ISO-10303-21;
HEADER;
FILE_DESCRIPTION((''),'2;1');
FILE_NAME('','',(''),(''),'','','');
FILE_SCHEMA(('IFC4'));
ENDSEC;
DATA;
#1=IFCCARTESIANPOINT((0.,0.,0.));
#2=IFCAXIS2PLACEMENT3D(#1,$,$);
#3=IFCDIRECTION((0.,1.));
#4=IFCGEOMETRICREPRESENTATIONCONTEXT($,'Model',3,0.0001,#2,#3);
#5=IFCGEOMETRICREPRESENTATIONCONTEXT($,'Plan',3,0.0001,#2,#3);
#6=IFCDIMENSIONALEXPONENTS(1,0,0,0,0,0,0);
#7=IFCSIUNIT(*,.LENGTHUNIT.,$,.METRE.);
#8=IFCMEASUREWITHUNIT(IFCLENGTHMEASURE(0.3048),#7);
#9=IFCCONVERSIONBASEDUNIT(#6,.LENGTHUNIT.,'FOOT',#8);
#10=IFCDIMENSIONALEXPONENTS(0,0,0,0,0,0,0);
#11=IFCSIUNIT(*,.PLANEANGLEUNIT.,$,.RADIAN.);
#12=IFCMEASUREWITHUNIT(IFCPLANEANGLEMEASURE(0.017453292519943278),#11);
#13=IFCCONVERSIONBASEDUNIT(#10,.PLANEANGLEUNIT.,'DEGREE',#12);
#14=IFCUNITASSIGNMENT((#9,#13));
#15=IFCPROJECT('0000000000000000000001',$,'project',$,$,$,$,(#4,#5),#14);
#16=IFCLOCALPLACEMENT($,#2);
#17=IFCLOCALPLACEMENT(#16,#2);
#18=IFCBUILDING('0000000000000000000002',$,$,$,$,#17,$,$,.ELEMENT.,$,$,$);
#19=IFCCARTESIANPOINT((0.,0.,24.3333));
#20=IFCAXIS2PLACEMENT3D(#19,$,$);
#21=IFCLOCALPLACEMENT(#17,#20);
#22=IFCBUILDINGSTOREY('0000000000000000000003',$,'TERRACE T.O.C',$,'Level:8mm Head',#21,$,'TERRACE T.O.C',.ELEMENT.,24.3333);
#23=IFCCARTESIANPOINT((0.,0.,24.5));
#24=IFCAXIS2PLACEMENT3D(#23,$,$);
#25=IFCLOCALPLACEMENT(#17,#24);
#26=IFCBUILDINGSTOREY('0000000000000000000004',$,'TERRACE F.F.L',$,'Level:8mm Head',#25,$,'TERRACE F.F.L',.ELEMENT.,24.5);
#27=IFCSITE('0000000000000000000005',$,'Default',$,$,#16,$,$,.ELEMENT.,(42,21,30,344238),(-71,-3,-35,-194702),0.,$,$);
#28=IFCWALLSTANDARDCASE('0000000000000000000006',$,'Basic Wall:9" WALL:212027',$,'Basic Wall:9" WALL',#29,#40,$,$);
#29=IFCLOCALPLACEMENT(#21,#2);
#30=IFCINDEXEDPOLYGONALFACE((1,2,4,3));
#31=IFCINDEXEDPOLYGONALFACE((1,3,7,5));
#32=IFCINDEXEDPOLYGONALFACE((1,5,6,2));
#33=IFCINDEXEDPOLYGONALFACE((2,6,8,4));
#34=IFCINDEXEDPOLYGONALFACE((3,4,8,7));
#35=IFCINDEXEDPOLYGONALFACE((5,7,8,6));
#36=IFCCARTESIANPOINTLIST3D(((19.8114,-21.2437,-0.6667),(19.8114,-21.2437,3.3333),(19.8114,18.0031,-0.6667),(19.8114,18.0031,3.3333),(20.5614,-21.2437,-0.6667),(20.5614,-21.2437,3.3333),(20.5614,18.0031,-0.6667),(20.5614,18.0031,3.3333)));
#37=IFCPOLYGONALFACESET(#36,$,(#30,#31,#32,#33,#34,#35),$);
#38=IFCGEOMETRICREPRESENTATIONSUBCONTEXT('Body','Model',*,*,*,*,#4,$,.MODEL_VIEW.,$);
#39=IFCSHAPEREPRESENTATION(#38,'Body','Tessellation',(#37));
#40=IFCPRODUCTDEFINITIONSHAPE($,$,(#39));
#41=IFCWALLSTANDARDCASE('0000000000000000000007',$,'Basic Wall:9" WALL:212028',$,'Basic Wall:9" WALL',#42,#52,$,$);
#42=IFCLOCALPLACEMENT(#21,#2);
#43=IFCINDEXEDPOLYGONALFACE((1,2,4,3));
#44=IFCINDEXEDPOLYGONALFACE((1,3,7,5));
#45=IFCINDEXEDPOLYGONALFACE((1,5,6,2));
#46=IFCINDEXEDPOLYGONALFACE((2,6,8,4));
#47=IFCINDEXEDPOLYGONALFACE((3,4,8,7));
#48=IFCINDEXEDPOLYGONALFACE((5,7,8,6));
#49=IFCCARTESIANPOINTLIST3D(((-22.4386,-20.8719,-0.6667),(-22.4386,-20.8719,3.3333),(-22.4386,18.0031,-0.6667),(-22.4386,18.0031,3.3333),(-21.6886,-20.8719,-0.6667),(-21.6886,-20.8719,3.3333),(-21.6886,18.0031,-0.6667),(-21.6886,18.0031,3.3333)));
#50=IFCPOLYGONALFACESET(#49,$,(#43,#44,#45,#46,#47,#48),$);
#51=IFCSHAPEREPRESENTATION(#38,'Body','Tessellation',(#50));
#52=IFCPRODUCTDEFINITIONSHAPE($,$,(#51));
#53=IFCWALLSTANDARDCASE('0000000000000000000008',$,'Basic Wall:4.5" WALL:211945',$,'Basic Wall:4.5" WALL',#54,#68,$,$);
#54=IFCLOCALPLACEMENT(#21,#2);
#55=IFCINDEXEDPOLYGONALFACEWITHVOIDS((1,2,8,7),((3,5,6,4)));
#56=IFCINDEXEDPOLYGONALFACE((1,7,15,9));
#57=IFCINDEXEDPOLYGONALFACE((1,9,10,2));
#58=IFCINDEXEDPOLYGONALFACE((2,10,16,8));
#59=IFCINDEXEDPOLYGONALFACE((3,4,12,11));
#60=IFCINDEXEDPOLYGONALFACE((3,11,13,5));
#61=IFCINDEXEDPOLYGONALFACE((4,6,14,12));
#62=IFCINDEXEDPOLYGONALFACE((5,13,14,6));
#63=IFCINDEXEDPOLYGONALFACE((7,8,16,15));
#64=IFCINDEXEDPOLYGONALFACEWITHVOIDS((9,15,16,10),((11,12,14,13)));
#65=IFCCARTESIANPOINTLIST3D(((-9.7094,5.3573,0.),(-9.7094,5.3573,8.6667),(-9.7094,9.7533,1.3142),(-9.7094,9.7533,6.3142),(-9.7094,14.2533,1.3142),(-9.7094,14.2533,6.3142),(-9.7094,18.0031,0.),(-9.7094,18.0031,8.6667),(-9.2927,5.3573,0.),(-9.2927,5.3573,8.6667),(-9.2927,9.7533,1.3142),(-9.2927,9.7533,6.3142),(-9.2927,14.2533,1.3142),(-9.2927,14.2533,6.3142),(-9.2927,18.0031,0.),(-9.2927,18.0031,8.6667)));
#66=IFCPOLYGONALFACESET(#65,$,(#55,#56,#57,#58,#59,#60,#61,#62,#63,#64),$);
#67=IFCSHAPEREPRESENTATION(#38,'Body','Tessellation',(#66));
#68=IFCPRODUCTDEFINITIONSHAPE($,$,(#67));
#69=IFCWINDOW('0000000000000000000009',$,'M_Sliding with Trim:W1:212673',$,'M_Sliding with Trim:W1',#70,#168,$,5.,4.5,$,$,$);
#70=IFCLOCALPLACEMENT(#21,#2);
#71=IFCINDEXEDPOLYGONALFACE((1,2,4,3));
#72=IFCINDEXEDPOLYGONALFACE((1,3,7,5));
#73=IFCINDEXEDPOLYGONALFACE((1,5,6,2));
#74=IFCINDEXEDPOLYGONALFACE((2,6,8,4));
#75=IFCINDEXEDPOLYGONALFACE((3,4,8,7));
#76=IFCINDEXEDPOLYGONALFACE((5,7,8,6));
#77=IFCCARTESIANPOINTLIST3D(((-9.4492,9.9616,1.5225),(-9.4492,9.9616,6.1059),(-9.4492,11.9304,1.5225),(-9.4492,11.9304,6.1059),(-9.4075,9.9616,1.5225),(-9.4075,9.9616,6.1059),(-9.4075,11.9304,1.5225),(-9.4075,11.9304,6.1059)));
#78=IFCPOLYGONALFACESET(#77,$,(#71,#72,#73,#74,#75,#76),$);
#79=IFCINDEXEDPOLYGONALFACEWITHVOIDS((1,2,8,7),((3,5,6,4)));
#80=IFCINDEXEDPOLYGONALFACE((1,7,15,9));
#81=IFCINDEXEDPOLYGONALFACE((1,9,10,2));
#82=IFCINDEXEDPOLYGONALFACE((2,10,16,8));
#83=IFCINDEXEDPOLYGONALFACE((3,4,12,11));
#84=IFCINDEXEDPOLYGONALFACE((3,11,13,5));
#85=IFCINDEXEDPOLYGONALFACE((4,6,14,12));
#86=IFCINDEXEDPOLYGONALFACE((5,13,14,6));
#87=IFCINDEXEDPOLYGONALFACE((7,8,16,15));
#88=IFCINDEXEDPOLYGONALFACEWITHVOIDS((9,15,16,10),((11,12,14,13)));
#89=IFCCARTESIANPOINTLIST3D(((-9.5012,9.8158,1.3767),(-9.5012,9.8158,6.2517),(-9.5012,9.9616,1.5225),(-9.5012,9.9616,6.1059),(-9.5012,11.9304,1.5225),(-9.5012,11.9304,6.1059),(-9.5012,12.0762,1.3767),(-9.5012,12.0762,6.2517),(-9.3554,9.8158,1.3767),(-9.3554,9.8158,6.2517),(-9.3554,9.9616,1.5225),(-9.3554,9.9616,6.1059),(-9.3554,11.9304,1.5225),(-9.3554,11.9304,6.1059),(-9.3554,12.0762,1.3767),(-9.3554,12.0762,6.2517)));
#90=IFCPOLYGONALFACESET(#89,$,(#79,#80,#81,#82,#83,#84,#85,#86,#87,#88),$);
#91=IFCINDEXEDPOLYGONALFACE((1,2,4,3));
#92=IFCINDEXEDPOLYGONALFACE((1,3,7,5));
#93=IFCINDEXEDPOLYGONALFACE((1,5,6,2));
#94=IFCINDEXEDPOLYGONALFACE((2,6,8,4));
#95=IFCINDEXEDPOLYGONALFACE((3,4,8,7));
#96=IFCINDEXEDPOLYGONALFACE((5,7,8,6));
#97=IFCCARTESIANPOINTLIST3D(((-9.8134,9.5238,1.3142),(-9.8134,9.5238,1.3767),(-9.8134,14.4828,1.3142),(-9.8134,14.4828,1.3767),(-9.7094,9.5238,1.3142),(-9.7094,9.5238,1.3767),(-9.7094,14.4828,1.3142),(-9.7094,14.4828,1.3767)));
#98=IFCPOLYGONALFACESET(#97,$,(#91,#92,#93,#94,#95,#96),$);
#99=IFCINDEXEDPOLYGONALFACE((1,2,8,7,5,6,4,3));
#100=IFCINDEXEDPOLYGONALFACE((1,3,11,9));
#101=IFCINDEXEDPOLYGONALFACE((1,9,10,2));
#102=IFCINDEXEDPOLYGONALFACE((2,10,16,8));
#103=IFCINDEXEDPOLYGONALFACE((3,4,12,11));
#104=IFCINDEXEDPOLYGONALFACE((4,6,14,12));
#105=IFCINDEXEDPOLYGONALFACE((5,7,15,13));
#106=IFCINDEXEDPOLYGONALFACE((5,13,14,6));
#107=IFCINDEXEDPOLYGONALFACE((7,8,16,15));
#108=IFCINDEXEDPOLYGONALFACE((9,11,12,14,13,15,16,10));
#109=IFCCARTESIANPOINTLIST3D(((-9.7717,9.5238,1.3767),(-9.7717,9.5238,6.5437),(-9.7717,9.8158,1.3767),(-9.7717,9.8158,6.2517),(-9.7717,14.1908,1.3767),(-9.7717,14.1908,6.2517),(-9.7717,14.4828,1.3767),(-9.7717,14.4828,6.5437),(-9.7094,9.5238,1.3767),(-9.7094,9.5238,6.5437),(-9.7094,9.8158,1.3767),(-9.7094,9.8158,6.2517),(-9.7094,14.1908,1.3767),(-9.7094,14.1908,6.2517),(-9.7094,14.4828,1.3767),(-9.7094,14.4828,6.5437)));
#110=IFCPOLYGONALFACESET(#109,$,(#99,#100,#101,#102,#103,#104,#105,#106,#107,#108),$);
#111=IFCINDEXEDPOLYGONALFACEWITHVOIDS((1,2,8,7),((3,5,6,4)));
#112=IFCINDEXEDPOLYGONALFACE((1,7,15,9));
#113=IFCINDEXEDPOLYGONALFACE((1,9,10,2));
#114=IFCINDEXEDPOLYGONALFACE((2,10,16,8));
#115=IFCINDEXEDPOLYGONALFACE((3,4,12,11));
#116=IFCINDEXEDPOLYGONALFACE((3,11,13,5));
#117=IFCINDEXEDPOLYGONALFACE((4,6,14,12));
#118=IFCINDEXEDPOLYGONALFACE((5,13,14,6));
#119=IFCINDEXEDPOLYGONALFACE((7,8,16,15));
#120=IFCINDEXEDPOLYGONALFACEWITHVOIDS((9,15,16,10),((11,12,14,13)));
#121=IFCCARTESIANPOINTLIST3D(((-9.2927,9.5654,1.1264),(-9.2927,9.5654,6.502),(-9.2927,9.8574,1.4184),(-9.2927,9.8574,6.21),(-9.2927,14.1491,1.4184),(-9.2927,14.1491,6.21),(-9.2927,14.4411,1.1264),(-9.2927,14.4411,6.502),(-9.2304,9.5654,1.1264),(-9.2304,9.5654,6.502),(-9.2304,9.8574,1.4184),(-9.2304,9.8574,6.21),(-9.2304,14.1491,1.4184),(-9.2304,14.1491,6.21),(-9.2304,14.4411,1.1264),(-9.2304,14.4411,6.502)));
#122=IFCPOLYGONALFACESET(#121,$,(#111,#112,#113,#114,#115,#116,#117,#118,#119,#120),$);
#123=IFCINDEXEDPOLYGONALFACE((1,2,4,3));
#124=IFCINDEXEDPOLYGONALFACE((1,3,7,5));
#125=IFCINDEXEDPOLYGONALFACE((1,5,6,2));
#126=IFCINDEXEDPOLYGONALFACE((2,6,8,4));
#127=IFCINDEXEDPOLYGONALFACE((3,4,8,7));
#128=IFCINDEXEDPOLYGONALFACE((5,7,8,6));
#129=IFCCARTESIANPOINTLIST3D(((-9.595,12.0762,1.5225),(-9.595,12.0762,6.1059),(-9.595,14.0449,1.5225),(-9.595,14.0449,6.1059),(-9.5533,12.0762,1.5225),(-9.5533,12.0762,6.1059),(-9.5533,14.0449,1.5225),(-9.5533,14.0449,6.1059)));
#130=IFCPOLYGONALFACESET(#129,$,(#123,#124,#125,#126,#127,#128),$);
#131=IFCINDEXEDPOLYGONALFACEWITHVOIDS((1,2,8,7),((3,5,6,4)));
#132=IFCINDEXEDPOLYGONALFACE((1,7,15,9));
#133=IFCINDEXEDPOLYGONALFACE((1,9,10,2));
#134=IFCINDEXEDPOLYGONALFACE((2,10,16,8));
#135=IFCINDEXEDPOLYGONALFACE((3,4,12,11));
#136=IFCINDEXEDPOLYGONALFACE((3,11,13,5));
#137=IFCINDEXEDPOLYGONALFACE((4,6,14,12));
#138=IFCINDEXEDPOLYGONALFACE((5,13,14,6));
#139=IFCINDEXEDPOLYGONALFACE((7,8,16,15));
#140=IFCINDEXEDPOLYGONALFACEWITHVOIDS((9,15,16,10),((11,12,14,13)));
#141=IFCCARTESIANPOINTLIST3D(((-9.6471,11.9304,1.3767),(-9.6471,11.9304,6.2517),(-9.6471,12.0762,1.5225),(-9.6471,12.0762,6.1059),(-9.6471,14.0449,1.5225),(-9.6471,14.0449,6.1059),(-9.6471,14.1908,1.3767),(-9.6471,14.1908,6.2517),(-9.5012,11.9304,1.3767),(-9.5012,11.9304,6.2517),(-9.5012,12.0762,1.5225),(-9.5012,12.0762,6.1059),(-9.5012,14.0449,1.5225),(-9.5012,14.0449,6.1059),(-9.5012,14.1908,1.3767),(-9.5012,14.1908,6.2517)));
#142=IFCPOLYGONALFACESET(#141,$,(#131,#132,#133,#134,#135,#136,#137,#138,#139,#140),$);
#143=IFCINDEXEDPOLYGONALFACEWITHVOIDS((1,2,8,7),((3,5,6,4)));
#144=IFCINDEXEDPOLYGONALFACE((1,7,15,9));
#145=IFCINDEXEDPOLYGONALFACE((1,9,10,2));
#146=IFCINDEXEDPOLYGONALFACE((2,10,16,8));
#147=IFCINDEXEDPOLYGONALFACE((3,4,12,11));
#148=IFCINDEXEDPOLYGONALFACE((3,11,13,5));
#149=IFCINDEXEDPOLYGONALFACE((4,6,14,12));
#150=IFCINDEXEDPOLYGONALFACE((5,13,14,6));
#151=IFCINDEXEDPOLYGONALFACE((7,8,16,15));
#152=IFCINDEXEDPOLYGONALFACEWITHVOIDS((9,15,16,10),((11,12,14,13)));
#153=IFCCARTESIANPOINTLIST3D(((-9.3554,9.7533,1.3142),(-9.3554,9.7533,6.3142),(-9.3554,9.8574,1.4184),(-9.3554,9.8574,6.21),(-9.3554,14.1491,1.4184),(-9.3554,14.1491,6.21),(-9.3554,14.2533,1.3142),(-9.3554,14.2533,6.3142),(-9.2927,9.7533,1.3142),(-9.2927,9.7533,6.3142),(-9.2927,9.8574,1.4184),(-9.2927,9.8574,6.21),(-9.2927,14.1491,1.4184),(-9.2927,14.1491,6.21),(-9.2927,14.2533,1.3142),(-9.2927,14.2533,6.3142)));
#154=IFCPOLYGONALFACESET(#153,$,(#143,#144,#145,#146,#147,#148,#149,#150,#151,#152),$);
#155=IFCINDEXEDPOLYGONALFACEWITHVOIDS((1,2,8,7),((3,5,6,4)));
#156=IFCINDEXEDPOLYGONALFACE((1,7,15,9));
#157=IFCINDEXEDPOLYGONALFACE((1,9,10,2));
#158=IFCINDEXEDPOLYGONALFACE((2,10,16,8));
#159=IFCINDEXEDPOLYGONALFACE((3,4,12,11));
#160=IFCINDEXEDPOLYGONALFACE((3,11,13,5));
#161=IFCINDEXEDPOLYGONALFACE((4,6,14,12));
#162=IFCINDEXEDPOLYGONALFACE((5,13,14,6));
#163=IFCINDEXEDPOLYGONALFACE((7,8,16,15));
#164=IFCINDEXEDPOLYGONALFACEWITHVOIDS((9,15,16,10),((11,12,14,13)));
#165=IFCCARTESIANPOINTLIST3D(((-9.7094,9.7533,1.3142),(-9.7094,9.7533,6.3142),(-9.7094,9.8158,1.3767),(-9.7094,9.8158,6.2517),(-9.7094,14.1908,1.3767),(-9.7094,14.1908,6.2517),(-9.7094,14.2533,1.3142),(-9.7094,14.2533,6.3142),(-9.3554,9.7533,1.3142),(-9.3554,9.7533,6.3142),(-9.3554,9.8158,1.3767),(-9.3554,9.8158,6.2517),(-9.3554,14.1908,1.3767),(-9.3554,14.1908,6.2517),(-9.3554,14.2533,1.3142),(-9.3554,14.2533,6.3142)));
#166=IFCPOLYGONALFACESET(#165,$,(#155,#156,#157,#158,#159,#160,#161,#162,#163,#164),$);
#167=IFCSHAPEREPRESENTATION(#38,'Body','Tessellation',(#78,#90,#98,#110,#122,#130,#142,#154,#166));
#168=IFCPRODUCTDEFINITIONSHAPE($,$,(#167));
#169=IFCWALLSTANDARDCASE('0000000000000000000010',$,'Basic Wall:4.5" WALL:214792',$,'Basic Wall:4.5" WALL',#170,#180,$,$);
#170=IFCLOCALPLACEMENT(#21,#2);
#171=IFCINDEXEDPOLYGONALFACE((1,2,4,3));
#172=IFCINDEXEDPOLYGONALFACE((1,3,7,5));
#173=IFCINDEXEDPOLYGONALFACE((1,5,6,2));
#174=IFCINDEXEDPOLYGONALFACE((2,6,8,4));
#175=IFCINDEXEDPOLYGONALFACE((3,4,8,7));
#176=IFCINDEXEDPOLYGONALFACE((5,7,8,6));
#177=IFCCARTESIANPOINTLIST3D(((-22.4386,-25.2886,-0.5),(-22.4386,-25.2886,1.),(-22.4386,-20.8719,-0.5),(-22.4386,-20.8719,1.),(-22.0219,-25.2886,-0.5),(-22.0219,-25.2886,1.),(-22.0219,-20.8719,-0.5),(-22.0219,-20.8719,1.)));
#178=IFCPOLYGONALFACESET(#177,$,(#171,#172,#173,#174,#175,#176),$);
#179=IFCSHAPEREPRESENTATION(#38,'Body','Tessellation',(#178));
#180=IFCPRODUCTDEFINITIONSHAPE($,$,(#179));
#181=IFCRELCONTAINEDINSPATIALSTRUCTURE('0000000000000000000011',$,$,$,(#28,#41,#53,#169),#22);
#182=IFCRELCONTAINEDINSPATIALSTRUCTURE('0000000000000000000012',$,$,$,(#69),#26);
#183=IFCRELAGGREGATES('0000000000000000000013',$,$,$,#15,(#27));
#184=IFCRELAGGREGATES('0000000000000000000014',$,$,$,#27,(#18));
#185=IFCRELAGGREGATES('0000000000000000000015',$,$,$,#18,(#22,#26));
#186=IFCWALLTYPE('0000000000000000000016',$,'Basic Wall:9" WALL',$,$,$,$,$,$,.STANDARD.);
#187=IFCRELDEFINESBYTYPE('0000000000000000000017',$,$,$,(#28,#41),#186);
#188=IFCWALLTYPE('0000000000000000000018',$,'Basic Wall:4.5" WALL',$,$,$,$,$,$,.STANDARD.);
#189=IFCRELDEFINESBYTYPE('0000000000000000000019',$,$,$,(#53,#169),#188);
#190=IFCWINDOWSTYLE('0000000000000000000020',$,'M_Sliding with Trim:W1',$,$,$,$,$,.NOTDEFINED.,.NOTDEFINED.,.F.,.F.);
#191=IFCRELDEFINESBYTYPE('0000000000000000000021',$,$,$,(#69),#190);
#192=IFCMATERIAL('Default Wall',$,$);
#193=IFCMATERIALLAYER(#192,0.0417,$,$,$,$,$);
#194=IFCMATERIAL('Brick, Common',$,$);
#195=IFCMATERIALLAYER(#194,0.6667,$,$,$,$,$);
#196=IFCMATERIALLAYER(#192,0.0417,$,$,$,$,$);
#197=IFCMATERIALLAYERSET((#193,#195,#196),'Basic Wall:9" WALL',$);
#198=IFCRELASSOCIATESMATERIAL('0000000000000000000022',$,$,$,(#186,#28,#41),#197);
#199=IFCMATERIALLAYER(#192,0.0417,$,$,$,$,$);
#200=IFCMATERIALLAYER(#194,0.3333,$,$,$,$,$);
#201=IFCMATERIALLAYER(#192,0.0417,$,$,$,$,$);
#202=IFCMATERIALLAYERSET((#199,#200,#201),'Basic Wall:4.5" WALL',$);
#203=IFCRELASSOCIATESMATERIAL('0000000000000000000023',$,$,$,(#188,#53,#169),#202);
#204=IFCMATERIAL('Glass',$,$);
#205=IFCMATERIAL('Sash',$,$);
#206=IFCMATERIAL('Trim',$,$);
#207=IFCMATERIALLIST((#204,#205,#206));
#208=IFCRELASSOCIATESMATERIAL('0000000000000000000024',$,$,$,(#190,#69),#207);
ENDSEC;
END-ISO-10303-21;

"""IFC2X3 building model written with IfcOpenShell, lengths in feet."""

from ifc_helpers import new_model, entity, si_unit, converted_unit, direction, frame, frame_2d, origin, origin_2d_with_axis, place, context, subcontext, project, spatial, polyline, rectangle, outline, extrude, clip, bounded_halfspace, source, transform, mapped, material, material_list, layer, layer_set, layer_usage, type_object, type_shapes, element, fill, save


model = new_model("IFC2X3")

# Units and contexts
model_context = context("Model", 3, precision=0.0001, world=origin(), true_north=direction((0.0, 1.0)))
plan_context = context("Plan", 3, precision=0.0001, world=origin(), true_north=direction((0.0, 1.0)))
body_context = subcontext(model_context, "Body", "Model", "MODEL_VIEW")
ifc_project = project(units=[converted_unit("LENGTHUNIT", "FOOT", entity("IfcLengthMeasure", 0.3048), si_unit("LENGTHUNIT", "METRE"), dimensions=[1, 0, 0, 0, 0, 0, 0]), converted_unit("PLANEANGLEUNIT", "DEGREE", entity("IfcPlaneAngleMeasure", 0.017453292519943278), si_unit("PLANEANGLEUNIT", "RADIAN"), dimensions=[0, 0, 0, 0, 0, 0, 0])], contexts=[model_context, plan_context])

# Site, building, storey
site_placement = place(None, origin())
site = spatial("IfcSite", under=ifc_project, at=site_placement, Name="Default", CompositionType="ELEMENT", RefLatitude=(42, 21, 30, 344238), RefLongitude=(-71, -3, -35, -194702), RefElevation=0.0)
building_placement = place(site_placement, origin())
building = spatial("IfcBuilding", under=site, at=building_placement, CompositionType="ELEMENT")
storey_1_placement = place(building_placement, frame((0.0, 0.0, 24.3333)))
storey_1 = spatial("IfcBuildingStorey", under=building, at=storey_1_placement, Name="TERRACE T.O.C", ObjectType="Level:8mm Head", LongName="TERRACE T.O.C", CompositionType="ELEMENT", Elevation=24.3333)

# Walls
ifc_material_1 = material(Name="Default Wall")
ifc_layer_1 = layer(ifc_material_1, 0.0417)
ifc_material_2 = material(Name="Brick, Common")
ifc_layer_2 = layer(ifc_material_2, 0.6667)
ifc_layer_3 = layer(ifc_material_1, 0.0417)
ifc_layer_set_1 = layer_set([ifc_layer_1, ifc_layer_2, ifc_layer_3], Name="Basic Wall:9\" WALL")
ifc_layer_usage_1 = layer_usage(ifc_layer_set_1, "AXIS2", "NEGATIVE", 0.375)
wall_type_1 = type_object("IfcWallType", Name="Basic Wall:9\" WALL", PredefinedType="STANDARD", material=ifc_layer_set_1)
wall_1_placement = place(storey_1_placement, frame((20.1864, 18.0031, -0.6667), z_axis=(0.0, 0.0, 1.0), x_axis=(0.0, -1.0, 0.0)))
element("IfcWallStandardCase", 1, at=wall_1_placement, inside=storey_1, type_object=wall_type_1, material=ifc_layer_usage_1, Name="Basic Wall:9\" WALL:212027", ObjectType="Basic Wall:9\" WALL", context=body_context, shape_type="SweptSolid", body=[
    extrude(rectangle(XDim=39.2468, YDim=0.75, at=frame_2d((19.6234, 0.0), x_axis=(-1.0, 0.0))), origin(), (0.0, 0.0, 1.0), 4.0),
])
ifc_layer_usage_2 = layer_usage(ifc_layer_set_1, "AXIS2", "NEGATIVE", 0.375)
wall_2_placement = place(storey_1_placement, frame((-22.0636, 18.0031, -0.6667), z_axis=(0.0, 0.0, 1.0), x_axis=(0.0, -1.0, 0.0)))
element("IfcWallStandardCase", 2, at=wall_2_placement, inside=storey_1, type_object=wall_type_1, material=ifc_layer_usage_2, Name="Basic Wall:9\" WALL:212028", ObjectType="Basic Wall:9\" WALL", context=body_context, shape_type="SweptSolid", body=[
    extrude(rectangle(XDim=38.875, YDim=0.75, at=frame_2d((19.4375, 0.0), x_axis=(-1.0, 0.0))), origin(), (0.0, 0.0, 1.0), 4.0),
])

# Wall, opening
ifc_layer_4 = layer(ifc_material_1, 0.0417)
ifc_layer_5 = layer(ifc_material_2, 0.3333)
ifc_layer_6 = layer(ifc_material_1, 0.0417)
ifc_layer_set_2 = layer_set([ifc_layer_4, ifc_layer_5, ifc_layer_6], Name="Basic Wall:4.5\" WALL")
ifc_layer_usage_3 = layer_usage(ifc_layer_set_2, "AXIS2", "NEGATIVE", 0.2083)
wall_type_2 = type_object("IfcWallType", Name="Basic Wall:4.5\" WALL", PredefinedType="STANDARD", material=ifc_layer_set_2)
wall_3_placement = place(storey_1_placement, frame((-9.5011, 18.0031, 0.0), z_axis=(0.0, 0.0, 1.0), x_axis=(0.0, -1.0, 0.0)))
wall_3 = element("IfcWallStandardCase", 3, at=wall_3_placement, inside=storey_1, type_object=wall_type_2, material=ifc_layer_usage_3, Name="Basic Wall:4.5\" WALL:211945", ObjectType="Basic Wall:4.5\" WALL", context=body_context, shape_type="Clipping", body=[
    clip(extrude(rectangle(XDim=12.6458, YDim=0.4167, at=frame_2d((6.3229, 0.0), x_axis=(-1.0, 0.0))), origin(), (0.0, 0.0, 1.0), 8.6667), bounded_halfspace(frame((0.0, -0.2083, 8.6667), z_axis=(0.0, 0.0, -1.0), x_axis=(1.0, 0.0, 0.0)), True, frame((0.0, -0.2083, 8.6667)), polyline([(0.0, 0.0), (12.6458, 0.0), (12.6458, 0.4167), (12.2292, 0.4167), (0.0, 0.4167), (0.0, 0.0)]))),
])
opening_1_placement = place(wall_3_placement, frame((8.2498, 0.2083, 1.3142)))
opening_1 = element("IfcOpeningElement", 4, at=opening_1_placement, cuts=wall_3, ObjectType="Opening", context=body_context, shape_type="SweptSolid", body=[
    extrude(rectangle(XDim=5.0, YDim=4.5, at=frame_2d((2.5, 2.25), x_axis=(-1.0, 0.0))), frame((0.0, 0.0, 0.0), z_axis=(0.0, -1.0, 0.0), x_axis=(0.0, 0.0, 1.0)), (0.0, 0.0, 1.0), 0.4167),
])

# Shared definitions
storey_2_placement = place(building_placement, frame((0.0, 0.0, 24.5)))
storey_2 = spatial("IfcBuildingStorey", under=building, at=storey_2_placement, Name="TERRACE F.F.L", ObjectType="Level:8mm Head", LongName="TERRACE F.F.L", CompositionType="ELEMENT", Elevation=24.5)

# Window
ifc_material_3 = material(Name="Glass")
ifc_material_4 = material(Name="Sash")
ifc_material_5 = material(Name="Trim")
ifc_material_list_1 = material_list([ifc_material_3, ifc_material_4, ifc_material_5])
window_style = type_object("IfcWindowStyle", Name="M_Sliding with Trim:W1", ConstructionType="NOTDEFINED", OperationType="NOTDEFINED", ParameterTakesPrecedence=False, Sizeable=False, material=ifc_material_list_1)
shared_shape_1 = source(origin(), body_context, "Body", "SweptSolid", [
    extrude(rectangle(XDim=0.0417, YDim=1.9688, at=frame_2d((0.0, 0.0), x_axis=(1.0, 0.0))), frame((1.1927, 0.1356, 0.2083), z_axis=(0.0, 0.0, 1.0), x_axis=(0.0, -1.0, 0.0)), (0.0, 0.0, 1.0), 4.5833),
    extrude(outline(polyline([(-1.1302, -2.4375), (1.1302, -2.4375), (1.1302, 2.4375), (-1.1302, 2.4375), (-1.1302, -2.4375)]), holes=[polyline([(-0.9844, -2.2917), (-0.9844, 2.2917), (0.9844, 2.2917), (0.9844, -2.2917), (-0.9844, -2.2917)])]), frame((1.1927, 0.0627, 2.5), z_axis=(0.0, 1.0, 0.0), x_axis=(1.0, 0.0, 0.0)), (0.0, 0.0, 1.0), 0.1458),
    extrude(rectangle(XDim=0.104, YDim=4.959, at=frame_2d((0.0, 0.0), x_axis=(1.0, 0.0))), frame((2.25, 0.4687, 0.0), z_axis=(0.0, 0.0, 1.0), x_axis=(0.0, -1.0, 0.0)), (0.0, 0.0, 1.0), 0.0625),
    extrude(outline(polyline([(-2.3645, 2.1875), (2.5105, 2.1875), (2.5105, 2.4795), (-2.6565, 2.4795), (-2.6565, -2.4795), (2.5105, -2.4795), (2.5105, -2.1875), (-2.3645, -2.1875), (-2.3645, 2.1875)])), frame((2.25, 0.4167, 2.573), z_axis=(0.0, 1.0, 0.0), x_axis=(0.0, 0.0, -1.0)), (0.0, 0.0, 1.0), 0.0623),
    extrude(outline(polyline([(-2.6878, -2.4378), (2.6878, -2.4378), (2.6878, 2.4378), (-2.6878, 2.4378), (-2.6878, -2.4378)]), holes=[polyline([(-2.3958, -2.1458), (-2.3958, 2.1458), (2.3958, 2.1458), (2.3958, -2.1458), (-2.3958, -2.1458)])]), frame((2.25, -0.0623, 2.5), z_axis=(0.0, 1.0, 0.0), x_axis=(0.0, 0.0, -1.0)), (0.0, 0.0, 1.0), 0.0623),
    extrude(rectangle(XDim=0.0417, YDim=1.9687, at=origin_2d_with_axis()), frame((3.3073, 0.2814, 0.2083), z_axis=(0.0, 0.0, 1.0), x_axis=(0.0, 1.0, 0.0)), (0.0, 0.0, 1.0), 4.5833),
    extrude(outline(polyline([(-1.1302, -2.4375), (1.1302, -2.4375), (1.1302, 2.4375), (-1.1302, 2.4375), (-1.1302, -2.4375)]), holes=[polyline([(-0.9844, -2.2917), (-0.9844, 2.2917), (0.9844, 2.2917), (0.9844, -2.2917), (-0.9844, -2.2917)])]), frame((3.3073, 0.2085, 2.5), z_axis=(0.0, 1.0, 0.0), x_axis=(1.0, 0.0, 0.0)), (0.0, 0.0, 1.0), 0.1458),
    extrude(outline(polyline([(-2.25, -2.5), (2.25, -2.5), (2.25, 2.5), (-2.25, 2.5), (-2.25, -2.5)]), holes=[polyline([(-2.1458, -2.3958), (-2.1458, 2.3958), (2.1458, 2.3958), (2.1458, -2.3958), (-2.1458, -2.3958)])]), frame((2.25, 0.0, 2.5), z_axis=(0.0, 1.0, 0.0), x_axis=(1.0, 0.0, 0.0)), (0.0, 0.0, 1.0), 0.0627),
    extrude(outline(polyline([(-2.5, -2.25), (2.5, -2.25), (2.5, 2.25), (-2.5, 2.25), (-2.5, -2.25)]), holes=[polyline([(-2.4375, -2.1875), (-2.4375, 2.1875), (2.4375, 2.1875), (2.4375, -2.1875), (-2.4375, -2.1875)])]), frame((2.25, 0.0627, 2.5), z_axis=(0.0, 1.0, 0.0), x_axis=(0.0, 0.0, -1.0)), (0.0, 0.0, 1.0), 0.354),
])
type_shapes(window_style, [shared_shape_1])
window_placement = place(opening_1_placement, frame((0.0, 0.0, 0.0), z_axis=(0.0, 0.0, 1.0), x_axis=(-1.0, 0.0, 0.0)))
window = element("IfcWindow", 5, at=window_placement, inside=storey_2, type_object=window_style, material=ifc_material_list_1, Name="M_Sliding with Trim:W1:212673", ObjectType="M_Sliding with Trim:W1", OverallHeight=5.0, OverallWidth=4.5, context=body_context, shape_type="MappedRepresentation", body=[
    mapped(shared_shape_1, transform((0.0, 0.0, 0.0), scale=1.0)),
])
fill(opening_1, window)

# Wall
ifc_layer_usage_4 = layer_usage(ifc_layer_set_2, "AXIS2", "NEGATIVE", 0.2083)
wall_4_placement = place(storey_1_placement, frame((-22.2302, -20.8719, -0.5), z_axis=(0.0, 0.0, 1.0), x_axis=(0.0, -1.0, 0.0)))
element("IfcWallStandardCase", 6, at=wall_4_placement, inside=storey_1, type_object=wall_type_2, material=ifc_layer_usage_4, Name="Basic Wall:4.5\" WALL:214792", ObjectType="Basic Wall:4.5\" WALL", context=body_context, shape_type="SweptSolid", body=[
    extrude(rectangle(XDim=4.4167, YDim=0.4167, at=frame_2d((2.2083, 0.0), x_axis=(-1.0, 0.0))), origin(), (0.0, 0.0, 1.0), 1.5),
])

save(model, "model.ifc")
